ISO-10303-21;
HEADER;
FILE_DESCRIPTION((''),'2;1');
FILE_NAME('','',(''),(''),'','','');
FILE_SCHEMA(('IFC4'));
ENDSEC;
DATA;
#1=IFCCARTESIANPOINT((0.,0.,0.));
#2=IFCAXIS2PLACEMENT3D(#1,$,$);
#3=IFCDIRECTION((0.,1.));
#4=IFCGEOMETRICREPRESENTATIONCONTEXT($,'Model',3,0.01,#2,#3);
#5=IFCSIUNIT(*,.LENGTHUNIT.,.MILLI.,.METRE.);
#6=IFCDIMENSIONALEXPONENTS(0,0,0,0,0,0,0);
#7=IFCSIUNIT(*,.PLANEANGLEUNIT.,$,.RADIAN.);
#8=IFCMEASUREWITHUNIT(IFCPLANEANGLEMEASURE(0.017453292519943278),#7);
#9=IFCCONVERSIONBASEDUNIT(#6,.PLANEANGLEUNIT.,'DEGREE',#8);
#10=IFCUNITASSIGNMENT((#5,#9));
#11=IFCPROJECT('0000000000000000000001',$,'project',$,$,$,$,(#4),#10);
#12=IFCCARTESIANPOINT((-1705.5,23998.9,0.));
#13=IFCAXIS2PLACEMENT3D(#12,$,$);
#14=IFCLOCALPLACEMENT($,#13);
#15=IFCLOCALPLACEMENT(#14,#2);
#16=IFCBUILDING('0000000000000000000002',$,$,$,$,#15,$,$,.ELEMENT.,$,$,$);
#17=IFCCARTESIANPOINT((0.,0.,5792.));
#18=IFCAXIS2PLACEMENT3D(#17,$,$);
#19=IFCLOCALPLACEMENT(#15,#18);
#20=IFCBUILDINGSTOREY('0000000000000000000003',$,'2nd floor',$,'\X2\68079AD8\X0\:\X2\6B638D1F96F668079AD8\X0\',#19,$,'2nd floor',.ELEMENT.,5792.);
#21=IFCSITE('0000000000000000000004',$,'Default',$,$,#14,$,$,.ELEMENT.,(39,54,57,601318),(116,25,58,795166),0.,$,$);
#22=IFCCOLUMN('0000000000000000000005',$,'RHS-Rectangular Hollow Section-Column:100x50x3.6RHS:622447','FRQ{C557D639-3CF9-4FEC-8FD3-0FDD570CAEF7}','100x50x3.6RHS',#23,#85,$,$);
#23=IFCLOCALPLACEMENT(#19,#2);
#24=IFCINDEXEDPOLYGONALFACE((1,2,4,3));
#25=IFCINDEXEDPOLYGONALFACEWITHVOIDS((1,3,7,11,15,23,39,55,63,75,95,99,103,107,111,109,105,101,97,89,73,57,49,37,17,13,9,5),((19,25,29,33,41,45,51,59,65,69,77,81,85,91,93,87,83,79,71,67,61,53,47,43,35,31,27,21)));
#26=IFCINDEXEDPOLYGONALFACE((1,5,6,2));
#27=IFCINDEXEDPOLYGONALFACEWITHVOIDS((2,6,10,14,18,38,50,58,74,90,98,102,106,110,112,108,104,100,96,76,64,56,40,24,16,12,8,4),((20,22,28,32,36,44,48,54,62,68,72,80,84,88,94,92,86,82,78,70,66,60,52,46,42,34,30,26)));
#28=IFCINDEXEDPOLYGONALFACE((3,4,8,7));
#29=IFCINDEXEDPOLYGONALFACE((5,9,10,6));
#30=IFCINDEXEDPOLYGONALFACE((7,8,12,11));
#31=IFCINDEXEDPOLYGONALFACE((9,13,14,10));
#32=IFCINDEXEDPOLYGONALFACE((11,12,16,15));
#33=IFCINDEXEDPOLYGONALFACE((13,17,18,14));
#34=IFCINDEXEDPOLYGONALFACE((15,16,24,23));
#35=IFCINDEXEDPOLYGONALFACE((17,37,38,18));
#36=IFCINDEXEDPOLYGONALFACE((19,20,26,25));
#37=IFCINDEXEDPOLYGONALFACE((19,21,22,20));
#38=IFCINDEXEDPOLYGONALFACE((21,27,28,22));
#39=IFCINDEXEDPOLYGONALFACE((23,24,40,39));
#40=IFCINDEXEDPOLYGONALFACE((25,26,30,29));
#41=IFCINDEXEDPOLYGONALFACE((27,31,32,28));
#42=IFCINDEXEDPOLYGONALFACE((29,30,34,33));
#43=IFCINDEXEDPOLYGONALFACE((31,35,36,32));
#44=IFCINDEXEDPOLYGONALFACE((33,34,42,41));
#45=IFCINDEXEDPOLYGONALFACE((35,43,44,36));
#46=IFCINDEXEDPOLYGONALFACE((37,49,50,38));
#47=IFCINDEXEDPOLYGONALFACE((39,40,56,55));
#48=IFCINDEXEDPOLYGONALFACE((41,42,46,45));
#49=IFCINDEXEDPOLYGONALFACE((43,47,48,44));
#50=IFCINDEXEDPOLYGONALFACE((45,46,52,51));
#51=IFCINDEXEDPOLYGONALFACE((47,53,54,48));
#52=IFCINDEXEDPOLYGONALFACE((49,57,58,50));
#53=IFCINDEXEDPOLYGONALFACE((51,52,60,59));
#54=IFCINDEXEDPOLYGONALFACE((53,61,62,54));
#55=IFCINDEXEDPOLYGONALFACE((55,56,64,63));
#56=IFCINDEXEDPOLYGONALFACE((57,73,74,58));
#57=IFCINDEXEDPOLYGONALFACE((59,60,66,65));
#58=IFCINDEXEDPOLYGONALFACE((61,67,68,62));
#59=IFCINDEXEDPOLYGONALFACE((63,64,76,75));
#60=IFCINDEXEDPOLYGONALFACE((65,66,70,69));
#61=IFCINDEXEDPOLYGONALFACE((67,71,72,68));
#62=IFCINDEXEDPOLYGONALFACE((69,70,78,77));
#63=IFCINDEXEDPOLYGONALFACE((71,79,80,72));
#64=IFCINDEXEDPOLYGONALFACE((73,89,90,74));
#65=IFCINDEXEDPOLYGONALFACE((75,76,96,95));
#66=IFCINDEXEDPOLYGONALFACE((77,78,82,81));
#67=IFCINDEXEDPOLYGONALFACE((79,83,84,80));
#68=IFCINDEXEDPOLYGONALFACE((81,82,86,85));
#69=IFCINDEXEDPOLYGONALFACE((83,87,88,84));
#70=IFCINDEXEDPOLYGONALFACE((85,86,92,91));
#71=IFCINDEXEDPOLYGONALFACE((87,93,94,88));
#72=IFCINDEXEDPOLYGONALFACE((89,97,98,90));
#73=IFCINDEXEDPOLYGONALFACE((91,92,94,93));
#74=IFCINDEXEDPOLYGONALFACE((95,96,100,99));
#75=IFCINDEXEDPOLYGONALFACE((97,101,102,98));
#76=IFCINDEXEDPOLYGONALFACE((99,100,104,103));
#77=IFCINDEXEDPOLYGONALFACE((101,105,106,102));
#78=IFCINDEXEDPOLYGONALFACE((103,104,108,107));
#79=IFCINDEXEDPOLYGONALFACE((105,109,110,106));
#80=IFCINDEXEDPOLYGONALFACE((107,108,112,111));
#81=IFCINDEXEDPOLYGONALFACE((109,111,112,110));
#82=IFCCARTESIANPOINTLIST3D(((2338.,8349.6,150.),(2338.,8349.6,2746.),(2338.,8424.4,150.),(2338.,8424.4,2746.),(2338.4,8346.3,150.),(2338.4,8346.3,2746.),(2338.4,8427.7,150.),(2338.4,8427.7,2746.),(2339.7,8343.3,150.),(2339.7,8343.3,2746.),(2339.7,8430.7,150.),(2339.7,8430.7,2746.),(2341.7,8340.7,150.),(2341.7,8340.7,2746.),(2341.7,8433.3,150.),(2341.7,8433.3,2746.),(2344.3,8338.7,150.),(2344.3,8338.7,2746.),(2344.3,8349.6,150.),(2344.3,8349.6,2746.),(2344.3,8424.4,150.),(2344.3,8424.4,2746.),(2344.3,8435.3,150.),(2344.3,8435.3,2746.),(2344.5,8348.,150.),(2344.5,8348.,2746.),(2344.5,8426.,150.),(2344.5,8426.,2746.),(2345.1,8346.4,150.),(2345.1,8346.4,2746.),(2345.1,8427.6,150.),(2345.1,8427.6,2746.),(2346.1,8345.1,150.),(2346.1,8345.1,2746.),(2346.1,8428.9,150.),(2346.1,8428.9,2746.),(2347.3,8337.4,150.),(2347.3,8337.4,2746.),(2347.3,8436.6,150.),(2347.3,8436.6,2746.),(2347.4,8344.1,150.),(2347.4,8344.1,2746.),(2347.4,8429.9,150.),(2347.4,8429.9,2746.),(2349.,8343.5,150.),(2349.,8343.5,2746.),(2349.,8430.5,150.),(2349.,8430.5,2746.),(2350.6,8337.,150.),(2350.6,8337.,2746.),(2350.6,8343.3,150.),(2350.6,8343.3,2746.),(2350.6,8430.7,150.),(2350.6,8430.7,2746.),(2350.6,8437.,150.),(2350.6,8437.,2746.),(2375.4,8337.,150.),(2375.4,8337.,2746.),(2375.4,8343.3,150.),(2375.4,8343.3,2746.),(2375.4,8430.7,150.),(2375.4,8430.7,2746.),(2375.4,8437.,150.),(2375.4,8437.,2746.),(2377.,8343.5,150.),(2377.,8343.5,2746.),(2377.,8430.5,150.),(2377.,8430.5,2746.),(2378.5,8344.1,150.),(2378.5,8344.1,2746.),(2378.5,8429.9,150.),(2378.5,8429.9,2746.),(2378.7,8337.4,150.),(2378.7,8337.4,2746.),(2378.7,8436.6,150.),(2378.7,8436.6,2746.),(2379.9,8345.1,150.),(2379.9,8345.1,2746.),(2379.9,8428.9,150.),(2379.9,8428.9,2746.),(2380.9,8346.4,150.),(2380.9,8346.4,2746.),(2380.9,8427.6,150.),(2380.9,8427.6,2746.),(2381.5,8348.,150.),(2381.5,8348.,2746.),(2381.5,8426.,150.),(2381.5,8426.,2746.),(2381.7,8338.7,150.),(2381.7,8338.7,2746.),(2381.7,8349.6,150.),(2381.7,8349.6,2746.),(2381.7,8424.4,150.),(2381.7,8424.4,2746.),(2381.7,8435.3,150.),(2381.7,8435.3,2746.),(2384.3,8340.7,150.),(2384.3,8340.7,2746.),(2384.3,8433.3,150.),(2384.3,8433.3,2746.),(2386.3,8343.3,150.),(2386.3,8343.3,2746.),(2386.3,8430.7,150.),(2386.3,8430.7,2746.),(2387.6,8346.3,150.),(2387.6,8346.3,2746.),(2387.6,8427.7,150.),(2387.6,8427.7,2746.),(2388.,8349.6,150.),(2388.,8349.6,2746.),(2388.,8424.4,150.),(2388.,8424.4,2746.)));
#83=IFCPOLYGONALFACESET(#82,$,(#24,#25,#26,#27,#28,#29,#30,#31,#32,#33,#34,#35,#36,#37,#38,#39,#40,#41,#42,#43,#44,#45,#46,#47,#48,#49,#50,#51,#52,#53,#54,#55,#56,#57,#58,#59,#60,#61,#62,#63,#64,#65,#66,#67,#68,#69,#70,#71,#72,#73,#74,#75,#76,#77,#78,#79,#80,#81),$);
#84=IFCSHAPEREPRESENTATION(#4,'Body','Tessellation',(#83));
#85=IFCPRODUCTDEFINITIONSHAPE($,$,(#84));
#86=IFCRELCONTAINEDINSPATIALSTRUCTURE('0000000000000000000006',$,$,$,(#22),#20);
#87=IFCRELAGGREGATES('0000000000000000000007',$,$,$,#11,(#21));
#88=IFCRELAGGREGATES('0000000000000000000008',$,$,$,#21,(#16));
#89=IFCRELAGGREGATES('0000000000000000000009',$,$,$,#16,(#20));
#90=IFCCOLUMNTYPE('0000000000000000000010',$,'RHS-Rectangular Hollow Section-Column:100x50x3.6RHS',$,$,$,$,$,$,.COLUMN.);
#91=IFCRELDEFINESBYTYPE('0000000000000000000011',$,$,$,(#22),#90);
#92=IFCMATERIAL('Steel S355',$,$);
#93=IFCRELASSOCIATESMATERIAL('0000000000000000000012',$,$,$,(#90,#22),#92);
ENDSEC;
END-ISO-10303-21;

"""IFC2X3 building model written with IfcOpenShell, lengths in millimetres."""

from ifc_helpers import new_model, entity, si_unit, converted_unit, direction, frame, origin, origin_2d, place, context, project, spatial, hollow_rectangle, extrude, clip, halfspace, material, type_object, element, save


model = new_model("IFC2X3")

# Units and contexts
model_context = context("Model", 3, precision=0.01, world=origin(), true_north=direction((0.0, 1.0)))
ifc_project = project(units=[si_unit("LENGTHUNIT", "METRE", prefix="MILLI"), converted_unit("PLANEANGLEUNIT", "DEGREE", entity("IfcPlaneAngleMeasure", 0.017453292519943278), si_unit("PLANEANGLEUNIT", "RADIAN"), dimensions=[0, 0, 0, 0, 0, 0, 0])], contexts=[model_context])

# Site, building, storey
site_placement = place(None, frame((-1705.5, 23998.9, 0.0)))
site = spatial("IfcSite", under=ifc_project, at=site_placement, Name="Default", CompositionType="ELEMENT", RefLatitude=(39, 54, 57, 601318), RefLongitude=(116, 25, 58, 795166), RefElevation=0.0)
building_placement = place(site_placement, origin())
building = spatial("IfcBuilding", under=site, at=building_placement, CompositionType="ELEMENT")
storey_placement = place(building_placement, frame((0.0, 0.0, 5792.0)))
storey = spatial("IfcBuildingStorey", under=building, at=storey_placement, Name="2nd floor", ObjectType="标高:正负零标高", LongName="2nd floor", CompositionType="ELEMENT", Elevation=5792.0)

# Column
ifc_material_1 = material(Name="Steel S355")
column_type_1 = type_object("IfcColumnType", Name="RHS-Rectangular Hollow Section-Column:100x50x3.6RHS", PredefinedType="COLUMN", material=ifc_material_1)
column_1_placement = place(storey_placement, frame((2363.0, 8387.0, 2746.0), z_axis=(0.0, 0.0, 1.0), x_axis=(-1.0, 0.0, 0.0)))
element("IfcColumn", 1, at=column_1_placement, inside=storey, type_object=column_type_1, material=ifc_material_1, Name="RHS-Rectangular Hollow Section-Column:100x50x3.6RHS:622447", Description="FRQ{C557D639-3CF9-4FEC-8FD3-0FDD570CAEF7}", ObjectType="100x50x3.6RHS", context=model_context, shape_type="Clipping", body=[
    clip(extrude(hollow_rectangle(XDim=50.0, YDim=100.0, WallThickness=6.3, InnerFilletRadius=6.3, OuterFilletRadius=12.6, at=origin_2d()), origin(), (0.0, 0.0, -1.0), 2651.9), halfspace(frame((2363.0, 8387.0, -2596.0), z_axis=(0.0, 0.0, 1.0), x_axis=(-1.0, 0.0, 0.0)), True)),
])

save(model, "model.ifc")
